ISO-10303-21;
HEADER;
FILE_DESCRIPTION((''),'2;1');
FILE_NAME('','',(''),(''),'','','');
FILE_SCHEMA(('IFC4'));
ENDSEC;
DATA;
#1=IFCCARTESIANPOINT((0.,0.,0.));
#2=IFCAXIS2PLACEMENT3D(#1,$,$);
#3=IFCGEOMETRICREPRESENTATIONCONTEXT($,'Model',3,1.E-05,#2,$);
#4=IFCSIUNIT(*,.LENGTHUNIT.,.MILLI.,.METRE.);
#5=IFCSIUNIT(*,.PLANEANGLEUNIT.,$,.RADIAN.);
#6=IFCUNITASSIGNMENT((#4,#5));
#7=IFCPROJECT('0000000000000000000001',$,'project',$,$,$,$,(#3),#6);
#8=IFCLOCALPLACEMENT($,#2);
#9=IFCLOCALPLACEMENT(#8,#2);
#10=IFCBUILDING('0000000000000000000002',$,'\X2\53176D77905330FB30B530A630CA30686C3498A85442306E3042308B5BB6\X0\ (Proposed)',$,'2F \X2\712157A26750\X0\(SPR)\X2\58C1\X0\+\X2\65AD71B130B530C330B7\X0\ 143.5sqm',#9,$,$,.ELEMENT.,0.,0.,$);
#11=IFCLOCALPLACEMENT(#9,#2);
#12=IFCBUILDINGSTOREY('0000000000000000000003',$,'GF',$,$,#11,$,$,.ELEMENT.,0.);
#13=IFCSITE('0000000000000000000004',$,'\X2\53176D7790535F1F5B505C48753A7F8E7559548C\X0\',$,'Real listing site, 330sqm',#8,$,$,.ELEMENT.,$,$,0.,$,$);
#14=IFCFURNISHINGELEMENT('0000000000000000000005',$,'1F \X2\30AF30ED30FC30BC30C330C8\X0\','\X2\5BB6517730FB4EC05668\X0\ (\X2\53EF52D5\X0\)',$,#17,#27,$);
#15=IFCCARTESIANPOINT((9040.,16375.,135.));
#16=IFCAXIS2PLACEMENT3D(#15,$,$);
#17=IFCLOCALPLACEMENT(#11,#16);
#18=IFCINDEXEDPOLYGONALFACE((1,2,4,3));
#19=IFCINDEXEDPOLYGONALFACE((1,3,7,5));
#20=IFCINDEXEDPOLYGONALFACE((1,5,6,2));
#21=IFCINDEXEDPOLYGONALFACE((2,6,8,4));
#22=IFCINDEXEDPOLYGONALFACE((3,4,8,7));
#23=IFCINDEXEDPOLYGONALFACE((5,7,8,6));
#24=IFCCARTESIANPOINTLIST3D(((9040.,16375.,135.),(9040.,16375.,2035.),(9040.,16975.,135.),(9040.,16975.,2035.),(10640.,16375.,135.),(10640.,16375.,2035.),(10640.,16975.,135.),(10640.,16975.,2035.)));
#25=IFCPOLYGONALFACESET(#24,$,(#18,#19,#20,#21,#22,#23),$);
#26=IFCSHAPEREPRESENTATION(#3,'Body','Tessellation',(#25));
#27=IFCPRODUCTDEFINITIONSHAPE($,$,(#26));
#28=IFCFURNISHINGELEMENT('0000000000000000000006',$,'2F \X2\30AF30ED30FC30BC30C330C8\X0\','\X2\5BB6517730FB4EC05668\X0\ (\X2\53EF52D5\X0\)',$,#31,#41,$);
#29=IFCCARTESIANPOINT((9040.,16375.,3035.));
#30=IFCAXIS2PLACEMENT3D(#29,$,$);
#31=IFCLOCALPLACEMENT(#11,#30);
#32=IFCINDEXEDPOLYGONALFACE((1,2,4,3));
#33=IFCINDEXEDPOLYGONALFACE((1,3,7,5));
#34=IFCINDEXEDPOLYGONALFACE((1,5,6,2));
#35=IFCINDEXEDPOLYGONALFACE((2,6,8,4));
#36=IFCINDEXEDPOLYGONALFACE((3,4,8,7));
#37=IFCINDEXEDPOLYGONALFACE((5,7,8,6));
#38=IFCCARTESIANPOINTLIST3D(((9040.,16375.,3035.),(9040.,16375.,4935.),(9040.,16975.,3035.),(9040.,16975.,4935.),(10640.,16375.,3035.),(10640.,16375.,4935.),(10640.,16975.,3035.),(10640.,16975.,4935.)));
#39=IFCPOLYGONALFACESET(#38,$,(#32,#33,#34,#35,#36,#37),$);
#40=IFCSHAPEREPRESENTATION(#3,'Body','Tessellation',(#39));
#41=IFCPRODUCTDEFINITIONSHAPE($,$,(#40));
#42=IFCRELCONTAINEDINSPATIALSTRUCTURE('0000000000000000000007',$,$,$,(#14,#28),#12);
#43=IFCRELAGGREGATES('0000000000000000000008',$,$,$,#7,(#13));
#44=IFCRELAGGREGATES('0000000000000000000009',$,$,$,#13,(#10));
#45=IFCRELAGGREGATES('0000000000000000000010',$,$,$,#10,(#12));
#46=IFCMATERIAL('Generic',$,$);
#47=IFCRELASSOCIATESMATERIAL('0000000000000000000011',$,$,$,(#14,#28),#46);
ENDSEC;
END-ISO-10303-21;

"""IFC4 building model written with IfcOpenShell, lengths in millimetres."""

from ifc_helpers import new_model, si_unit, frame, frame_2d, origin, place, context, project, spatial, rectangle, extrude, material, element, save


model = new_model("IFC4")

# Units and contexts
model_context = context("Model", 3, precision=1e-05, world=origin())
ifc_project = project(units=[si_unit("LENGTHUNIT", "METRE", prefix="MILLI"), si_unit("PLANEANGLEUNIT", "RADIAN")], contexts=[model_context])

# Site, building, storey
site_placement = place(None, origin())
site = spatial("IfcSite", under=ifc_project, at=site_placement, Name="北海道弟子屈町美留和", ObjectType="Real listing site, 330sqm", CompositionType="ELEMENT", RefElevation=0.0)
building_placement = place(site_placement, origin())
building = spatial("IfcBuilding", under=site, at=building_placement, Name="北海道・サウナと水風呂のある家 (Proposed)", ObjectType="2F 無垢材(SPR)壁+断熱サッシ 143.5sqm", CompositionType="ELEMENT", ElevationOfRefHeight=0.0, ElevationOfTerrain=0.0)
storey_placement = place(building_placement, origin())
storey = spatial("IfcBuildingStorey", under=building, at=storey_placement, Name="GF", CompositionType="ELEMENT", Elevation=0.0)

# Shared definitions
ifc_material_1 = material(Name="Generic")

# Furnishing elements
furnishing_1_placement = place(storey_placement, frame((9040.0, 16375.0, 135.0)))
element("IfcFurnishingElement", 1, at=furnishing_1_placement, inside=storey, material=ifc_material_1, Name="1F クローゼット", Description="家具・什器 (可動)", context=model_context, shape_type="SweptSolid", body=[
    extrude(rectangle(XDim=1600.0, YDim=600.0, at=frame_2d((800.0, 300.0))), frame((9040.0, 16375.0, 135.0)), (0.0, 0.0, 1.0), 1900.0),
])
furnishing_2_placement = place(storey_placement, frame((9040.0, 16375.0, 3035.0)))
element("IfcFurnishingElement", 2, at=furnishing_2_placement, inside=storey, material=ifc_material_1, Name="2F クローゼット", Description="家具・什器 (可動)", context=model_context, shape_type="SweptSolid", body=[
    extrude(rectangle(XDim=1600.0, YDim=600.0, at=frame_2d((800.0, 300.0))), frame((9040.0, 16375.0, 3035.0)), (0.0, 0.0, 1.0), 1900.0),
])

save(model, "model.ifc")
